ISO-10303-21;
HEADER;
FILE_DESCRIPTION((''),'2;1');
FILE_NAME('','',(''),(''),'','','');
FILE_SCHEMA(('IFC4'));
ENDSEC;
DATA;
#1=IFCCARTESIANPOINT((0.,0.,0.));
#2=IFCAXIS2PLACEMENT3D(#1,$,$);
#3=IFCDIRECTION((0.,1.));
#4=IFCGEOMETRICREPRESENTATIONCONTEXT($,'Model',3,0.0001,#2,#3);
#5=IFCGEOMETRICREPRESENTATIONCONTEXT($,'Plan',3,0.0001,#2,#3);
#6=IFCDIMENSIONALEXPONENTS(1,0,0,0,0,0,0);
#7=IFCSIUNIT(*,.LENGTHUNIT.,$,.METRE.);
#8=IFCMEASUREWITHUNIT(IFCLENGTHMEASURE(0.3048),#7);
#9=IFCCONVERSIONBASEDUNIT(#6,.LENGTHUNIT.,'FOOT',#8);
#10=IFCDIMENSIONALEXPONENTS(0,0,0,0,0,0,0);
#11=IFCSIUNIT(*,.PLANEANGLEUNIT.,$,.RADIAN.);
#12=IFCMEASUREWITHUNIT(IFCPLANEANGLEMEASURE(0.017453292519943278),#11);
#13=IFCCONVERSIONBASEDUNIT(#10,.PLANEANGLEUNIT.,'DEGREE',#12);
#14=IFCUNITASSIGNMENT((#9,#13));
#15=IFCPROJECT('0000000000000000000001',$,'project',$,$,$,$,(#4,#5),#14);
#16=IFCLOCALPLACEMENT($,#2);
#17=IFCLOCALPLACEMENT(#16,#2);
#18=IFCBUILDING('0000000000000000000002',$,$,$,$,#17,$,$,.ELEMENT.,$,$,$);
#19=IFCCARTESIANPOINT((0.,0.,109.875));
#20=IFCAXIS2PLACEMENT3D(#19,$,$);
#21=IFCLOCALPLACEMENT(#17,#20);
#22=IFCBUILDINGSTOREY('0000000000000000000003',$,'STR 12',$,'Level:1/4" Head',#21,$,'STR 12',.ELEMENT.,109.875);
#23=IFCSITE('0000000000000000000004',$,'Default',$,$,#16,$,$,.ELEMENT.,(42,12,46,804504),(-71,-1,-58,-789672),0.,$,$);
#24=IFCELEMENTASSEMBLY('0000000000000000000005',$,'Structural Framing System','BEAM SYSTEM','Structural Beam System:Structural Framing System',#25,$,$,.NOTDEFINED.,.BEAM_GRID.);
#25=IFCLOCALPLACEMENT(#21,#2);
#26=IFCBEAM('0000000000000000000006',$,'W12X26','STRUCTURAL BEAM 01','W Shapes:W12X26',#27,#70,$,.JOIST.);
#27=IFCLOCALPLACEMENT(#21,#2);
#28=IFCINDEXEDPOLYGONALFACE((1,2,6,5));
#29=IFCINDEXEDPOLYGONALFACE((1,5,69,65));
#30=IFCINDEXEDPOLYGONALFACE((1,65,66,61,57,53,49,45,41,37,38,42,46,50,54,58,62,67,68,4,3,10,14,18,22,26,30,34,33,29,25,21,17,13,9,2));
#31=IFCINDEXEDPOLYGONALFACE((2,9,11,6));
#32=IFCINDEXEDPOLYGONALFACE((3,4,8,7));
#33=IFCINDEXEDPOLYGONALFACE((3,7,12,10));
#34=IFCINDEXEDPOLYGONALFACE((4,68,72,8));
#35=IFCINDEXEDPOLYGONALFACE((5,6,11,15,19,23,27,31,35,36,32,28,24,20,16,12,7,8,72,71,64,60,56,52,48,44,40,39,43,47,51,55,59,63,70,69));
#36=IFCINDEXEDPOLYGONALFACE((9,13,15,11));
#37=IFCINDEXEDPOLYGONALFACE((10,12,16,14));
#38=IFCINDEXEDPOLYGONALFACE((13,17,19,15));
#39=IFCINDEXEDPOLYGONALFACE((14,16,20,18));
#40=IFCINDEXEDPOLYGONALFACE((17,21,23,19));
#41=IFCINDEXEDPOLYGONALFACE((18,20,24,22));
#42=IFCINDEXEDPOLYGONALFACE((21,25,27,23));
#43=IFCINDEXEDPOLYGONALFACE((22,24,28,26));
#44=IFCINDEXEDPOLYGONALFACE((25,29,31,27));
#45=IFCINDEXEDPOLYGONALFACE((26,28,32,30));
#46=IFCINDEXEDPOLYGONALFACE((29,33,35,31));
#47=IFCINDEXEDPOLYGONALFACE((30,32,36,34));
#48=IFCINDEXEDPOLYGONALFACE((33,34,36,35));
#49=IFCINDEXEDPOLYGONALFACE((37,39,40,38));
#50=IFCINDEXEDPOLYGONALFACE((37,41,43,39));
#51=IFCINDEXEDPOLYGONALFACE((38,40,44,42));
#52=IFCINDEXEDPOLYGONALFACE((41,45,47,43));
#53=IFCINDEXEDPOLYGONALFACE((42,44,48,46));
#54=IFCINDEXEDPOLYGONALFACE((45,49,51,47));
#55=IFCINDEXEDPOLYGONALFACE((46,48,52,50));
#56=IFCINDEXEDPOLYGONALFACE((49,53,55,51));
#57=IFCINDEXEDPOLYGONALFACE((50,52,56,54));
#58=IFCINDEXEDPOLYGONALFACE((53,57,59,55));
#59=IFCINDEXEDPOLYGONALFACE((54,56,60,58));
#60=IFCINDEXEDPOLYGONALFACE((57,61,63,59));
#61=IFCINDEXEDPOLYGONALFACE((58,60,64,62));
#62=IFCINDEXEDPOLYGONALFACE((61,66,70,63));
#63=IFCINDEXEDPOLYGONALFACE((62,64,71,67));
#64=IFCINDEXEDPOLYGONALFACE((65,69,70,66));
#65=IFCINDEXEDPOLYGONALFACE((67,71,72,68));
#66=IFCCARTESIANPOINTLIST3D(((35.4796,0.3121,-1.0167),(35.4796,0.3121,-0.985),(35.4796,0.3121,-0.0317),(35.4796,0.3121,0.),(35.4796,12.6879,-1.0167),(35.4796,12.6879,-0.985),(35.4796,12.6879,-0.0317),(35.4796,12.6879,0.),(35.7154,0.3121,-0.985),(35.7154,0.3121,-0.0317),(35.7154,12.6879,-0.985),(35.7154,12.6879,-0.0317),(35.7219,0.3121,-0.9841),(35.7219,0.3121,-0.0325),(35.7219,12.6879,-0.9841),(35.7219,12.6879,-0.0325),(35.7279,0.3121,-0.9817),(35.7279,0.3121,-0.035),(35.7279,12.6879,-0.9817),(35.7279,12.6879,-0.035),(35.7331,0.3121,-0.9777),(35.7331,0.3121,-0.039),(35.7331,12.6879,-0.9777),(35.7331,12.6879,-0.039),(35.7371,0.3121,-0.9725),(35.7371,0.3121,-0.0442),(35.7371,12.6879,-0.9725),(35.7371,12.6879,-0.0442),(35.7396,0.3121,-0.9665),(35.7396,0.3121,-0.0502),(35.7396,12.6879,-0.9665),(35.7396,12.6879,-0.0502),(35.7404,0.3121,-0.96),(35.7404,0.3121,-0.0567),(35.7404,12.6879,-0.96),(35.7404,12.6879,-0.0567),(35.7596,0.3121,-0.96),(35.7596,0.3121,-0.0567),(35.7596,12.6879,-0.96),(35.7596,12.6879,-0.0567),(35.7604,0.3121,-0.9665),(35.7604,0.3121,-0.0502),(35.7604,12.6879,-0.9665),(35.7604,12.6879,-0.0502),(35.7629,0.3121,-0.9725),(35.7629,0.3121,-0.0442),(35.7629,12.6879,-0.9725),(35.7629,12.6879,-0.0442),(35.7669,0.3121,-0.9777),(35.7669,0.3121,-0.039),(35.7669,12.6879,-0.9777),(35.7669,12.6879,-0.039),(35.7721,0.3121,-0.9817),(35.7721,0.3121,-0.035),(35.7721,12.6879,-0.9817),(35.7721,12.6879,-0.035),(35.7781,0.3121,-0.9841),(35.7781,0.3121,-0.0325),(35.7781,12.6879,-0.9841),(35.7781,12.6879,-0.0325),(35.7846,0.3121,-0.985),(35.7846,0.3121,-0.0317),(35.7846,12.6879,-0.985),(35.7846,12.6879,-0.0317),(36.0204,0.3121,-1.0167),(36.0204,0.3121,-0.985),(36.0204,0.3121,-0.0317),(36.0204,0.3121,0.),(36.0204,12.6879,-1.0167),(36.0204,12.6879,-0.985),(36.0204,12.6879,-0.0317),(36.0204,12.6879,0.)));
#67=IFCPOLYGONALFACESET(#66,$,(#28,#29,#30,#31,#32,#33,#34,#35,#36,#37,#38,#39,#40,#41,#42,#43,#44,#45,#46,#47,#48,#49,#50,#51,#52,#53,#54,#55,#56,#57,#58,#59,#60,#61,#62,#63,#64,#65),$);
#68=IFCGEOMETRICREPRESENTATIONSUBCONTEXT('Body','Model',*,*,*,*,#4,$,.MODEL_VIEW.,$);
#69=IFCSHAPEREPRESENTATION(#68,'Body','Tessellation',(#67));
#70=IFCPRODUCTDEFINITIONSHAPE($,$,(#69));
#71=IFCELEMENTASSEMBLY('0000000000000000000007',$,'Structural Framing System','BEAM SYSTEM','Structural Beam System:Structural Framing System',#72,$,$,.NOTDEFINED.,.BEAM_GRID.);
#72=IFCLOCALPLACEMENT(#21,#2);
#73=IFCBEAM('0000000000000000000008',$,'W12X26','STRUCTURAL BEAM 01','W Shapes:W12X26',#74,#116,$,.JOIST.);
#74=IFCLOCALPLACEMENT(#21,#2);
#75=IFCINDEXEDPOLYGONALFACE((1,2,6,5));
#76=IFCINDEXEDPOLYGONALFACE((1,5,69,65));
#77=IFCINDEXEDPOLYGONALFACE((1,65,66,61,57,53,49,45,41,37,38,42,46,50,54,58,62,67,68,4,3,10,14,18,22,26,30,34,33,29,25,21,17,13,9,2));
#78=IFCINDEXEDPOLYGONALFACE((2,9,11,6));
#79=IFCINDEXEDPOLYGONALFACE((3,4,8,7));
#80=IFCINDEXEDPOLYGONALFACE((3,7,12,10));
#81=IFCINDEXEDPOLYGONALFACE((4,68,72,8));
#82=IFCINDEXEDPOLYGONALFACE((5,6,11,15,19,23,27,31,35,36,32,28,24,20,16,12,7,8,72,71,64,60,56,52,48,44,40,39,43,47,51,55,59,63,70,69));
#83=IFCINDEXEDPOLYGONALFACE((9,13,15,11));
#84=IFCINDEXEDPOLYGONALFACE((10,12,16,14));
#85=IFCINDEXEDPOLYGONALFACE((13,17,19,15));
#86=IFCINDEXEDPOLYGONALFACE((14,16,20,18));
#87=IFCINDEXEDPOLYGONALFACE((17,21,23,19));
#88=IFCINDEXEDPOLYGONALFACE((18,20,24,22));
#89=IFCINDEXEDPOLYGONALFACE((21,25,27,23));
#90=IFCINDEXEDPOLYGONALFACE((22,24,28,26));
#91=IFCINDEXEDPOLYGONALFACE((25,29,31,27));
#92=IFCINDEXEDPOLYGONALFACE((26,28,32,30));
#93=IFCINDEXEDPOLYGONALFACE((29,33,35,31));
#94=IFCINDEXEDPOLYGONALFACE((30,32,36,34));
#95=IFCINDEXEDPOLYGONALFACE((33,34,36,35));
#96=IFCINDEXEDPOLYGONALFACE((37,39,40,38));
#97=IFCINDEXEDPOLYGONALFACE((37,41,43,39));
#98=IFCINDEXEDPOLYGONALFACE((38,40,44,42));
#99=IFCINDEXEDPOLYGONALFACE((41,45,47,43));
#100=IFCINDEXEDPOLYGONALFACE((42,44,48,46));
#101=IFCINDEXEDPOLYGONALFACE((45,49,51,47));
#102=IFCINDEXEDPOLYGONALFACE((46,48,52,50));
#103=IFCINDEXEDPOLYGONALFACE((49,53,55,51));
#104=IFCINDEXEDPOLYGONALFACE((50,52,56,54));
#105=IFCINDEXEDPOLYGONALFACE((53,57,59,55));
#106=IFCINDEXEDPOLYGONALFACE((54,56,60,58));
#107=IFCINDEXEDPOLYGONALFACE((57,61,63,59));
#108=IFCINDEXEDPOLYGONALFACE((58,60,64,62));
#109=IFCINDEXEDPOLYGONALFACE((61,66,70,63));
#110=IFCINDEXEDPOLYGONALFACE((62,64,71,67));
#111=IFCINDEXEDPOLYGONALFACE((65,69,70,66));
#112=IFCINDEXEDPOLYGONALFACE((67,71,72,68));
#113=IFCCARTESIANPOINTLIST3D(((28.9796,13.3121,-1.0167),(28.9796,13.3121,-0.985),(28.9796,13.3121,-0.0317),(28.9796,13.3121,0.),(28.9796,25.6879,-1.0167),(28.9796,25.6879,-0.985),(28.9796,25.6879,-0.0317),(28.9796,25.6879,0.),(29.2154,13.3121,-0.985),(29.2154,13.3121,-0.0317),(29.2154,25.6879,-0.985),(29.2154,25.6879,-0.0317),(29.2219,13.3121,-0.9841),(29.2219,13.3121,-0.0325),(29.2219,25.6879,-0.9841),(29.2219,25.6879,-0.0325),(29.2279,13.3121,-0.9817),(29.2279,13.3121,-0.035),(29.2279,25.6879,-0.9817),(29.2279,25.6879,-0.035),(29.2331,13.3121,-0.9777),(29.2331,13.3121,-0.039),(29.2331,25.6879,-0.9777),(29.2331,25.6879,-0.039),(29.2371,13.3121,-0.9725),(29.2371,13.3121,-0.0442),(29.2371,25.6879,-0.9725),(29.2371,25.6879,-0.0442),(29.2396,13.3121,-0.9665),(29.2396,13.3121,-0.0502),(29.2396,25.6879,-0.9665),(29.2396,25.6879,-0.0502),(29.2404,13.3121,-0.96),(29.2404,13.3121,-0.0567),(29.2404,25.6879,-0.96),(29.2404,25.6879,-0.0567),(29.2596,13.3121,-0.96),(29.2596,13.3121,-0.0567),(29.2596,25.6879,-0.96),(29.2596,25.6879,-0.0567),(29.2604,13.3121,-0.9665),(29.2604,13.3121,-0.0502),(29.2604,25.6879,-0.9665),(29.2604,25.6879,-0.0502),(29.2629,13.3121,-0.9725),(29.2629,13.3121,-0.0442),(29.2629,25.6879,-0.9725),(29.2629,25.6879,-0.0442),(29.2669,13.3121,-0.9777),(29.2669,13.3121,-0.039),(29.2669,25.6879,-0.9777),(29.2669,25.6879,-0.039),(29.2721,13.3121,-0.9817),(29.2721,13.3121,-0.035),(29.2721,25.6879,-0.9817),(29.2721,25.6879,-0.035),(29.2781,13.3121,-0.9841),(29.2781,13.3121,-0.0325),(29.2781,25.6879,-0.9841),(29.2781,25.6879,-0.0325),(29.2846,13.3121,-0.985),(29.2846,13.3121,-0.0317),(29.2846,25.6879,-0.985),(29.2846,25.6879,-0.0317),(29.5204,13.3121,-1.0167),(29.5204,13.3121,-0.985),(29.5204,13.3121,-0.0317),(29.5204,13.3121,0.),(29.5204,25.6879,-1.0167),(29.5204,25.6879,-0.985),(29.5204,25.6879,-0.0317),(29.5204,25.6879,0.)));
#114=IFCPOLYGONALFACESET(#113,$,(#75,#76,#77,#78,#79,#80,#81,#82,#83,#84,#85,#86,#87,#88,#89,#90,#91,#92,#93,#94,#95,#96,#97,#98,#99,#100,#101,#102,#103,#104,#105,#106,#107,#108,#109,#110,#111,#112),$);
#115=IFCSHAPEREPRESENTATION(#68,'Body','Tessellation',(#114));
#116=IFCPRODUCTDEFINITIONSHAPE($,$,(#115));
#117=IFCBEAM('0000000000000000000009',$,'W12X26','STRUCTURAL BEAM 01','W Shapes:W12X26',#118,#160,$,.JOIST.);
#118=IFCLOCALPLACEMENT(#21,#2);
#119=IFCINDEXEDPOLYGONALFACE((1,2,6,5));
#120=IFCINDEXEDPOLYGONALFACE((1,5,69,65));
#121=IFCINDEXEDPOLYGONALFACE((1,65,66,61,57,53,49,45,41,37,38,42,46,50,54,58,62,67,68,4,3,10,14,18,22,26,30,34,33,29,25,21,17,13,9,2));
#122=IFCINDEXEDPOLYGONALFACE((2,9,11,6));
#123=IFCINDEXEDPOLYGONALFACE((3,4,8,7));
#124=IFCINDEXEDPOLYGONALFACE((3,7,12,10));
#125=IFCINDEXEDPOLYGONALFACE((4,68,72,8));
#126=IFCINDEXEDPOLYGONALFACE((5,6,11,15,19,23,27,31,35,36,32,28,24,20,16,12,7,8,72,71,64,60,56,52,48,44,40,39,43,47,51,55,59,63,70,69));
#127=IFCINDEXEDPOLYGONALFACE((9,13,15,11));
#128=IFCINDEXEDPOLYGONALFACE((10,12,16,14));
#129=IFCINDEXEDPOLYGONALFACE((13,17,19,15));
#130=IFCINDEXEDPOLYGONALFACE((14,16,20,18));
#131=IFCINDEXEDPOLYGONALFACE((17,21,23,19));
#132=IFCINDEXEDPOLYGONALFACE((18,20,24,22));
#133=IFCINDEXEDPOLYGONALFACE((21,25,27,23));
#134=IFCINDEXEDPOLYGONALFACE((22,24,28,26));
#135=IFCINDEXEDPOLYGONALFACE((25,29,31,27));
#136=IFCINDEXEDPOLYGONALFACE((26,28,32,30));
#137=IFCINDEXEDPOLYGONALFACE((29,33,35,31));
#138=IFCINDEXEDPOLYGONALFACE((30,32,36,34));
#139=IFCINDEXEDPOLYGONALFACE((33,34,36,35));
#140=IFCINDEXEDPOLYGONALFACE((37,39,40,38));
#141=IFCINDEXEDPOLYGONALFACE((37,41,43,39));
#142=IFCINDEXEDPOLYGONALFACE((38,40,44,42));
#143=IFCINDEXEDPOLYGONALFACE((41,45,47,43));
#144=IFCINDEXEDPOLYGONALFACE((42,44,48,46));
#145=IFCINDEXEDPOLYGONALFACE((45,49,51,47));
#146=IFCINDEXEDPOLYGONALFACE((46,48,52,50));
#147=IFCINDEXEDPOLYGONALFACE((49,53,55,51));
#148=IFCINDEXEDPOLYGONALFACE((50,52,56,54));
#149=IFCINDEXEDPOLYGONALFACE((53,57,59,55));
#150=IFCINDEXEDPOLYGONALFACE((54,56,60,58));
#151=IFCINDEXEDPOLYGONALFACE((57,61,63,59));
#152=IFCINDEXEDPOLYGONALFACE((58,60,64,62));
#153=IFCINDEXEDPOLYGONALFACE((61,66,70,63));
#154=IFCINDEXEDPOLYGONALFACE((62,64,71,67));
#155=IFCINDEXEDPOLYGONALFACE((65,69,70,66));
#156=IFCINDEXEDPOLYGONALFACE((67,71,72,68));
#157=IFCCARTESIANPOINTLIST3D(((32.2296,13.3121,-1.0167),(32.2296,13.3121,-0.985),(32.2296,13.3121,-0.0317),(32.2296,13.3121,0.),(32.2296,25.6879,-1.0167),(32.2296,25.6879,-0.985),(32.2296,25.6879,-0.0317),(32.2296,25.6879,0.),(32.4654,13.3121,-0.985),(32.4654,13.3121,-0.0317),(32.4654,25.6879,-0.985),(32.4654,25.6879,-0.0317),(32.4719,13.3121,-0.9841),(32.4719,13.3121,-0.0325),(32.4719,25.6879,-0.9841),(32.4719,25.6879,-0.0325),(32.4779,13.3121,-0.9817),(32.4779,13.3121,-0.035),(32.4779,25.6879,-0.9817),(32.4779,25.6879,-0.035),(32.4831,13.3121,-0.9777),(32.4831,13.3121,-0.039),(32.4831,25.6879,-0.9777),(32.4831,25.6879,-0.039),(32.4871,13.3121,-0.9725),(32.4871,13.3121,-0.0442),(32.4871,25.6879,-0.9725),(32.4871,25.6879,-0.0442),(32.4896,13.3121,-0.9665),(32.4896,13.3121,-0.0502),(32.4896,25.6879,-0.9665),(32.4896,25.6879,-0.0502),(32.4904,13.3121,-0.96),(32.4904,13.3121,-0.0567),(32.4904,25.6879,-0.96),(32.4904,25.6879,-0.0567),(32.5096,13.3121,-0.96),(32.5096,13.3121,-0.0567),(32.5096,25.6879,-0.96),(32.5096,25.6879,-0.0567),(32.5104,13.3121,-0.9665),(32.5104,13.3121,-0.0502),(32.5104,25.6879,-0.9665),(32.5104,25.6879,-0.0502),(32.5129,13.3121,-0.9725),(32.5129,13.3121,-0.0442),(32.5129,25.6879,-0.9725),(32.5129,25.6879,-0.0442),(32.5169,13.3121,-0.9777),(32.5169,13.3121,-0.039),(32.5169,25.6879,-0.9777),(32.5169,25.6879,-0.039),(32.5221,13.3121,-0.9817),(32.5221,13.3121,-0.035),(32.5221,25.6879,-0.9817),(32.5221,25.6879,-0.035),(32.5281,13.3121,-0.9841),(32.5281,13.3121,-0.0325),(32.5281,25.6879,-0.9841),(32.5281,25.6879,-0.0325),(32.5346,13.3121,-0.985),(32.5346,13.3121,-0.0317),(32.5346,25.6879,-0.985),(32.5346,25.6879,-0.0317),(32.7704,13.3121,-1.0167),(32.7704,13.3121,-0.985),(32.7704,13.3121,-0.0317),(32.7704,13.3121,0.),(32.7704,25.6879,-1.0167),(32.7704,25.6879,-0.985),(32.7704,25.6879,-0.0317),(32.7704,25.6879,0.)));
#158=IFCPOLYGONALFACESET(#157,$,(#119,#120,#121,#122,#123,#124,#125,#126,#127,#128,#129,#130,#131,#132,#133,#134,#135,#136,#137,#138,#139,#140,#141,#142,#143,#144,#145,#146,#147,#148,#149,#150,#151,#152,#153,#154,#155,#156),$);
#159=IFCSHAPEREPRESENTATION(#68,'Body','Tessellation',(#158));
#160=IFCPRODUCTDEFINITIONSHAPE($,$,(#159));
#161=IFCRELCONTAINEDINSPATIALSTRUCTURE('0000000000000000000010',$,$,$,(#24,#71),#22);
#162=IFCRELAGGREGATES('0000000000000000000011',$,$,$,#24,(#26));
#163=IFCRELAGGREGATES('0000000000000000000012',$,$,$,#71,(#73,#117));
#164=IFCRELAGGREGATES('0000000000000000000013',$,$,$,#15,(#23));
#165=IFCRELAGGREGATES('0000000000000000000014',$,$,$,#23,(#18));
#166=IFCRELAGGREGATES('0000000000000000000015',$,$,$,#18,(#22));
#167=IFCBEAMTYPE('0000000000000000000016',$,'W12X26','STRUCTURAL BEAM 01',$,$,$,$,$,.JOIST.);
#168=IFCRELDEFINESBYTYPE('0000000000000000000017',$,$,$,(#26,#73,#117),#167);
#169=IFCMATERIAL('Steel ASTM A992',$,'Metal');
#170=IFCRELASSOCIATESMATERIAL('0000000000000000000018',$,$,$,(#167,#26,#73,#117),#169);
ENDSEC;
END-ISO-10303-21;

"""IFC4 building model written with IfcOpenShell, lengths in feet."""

from ifc_helpers import new_model, entity, si_unit, converted_unit, direction, frame, origin, place, context, subcontext, project, spatial, line, arc, indexed_curve, outline, extrude, source, transform, mapped, material, type_object, type_shapes, element, aggregate, save


model = new_model("IFC4")

# Units and contexts
model_context = context("Model", 3, precision=0.0001, world=origin(), true_north=direction((0.0, 1.0)))
plan_context = context("Plan", 3, precision=0.0001, world=origin(), true_north=direction((0.0, 1.0)))
body_context = subcontext(model_context, "Body", "Model", "MODEL_VIEW")
ifc_project = project(units=[converted_unit("LENGTHUNIT", "FOOT", entity("IfcLengthMeasure", 0.3048), si_unit("LENGTHUNIT", "METRE"), dimensions=[1, 0, 0, 0, 0, 0, 0]), converted_unit("PLANEANGLEUNIT", "DEGREE", entity("IfcPlaneAngleMeasure", 0.017453292519943278), si_unit("PLANEANGLEUNIT", "RADIAN"), dimensions=[0, 0, 0, 0, 0, 0, 0])], contexts=[model_context, plan_context])

# Site, building, storey
site_placement = place(None, origin())
site = spatial("IfcSite", under=ifc_project, at=site_placement, Name="Default", CompositionType="ELEMENT", RefLatitude=(42, 12, 46, 804504), RefLongitude=(-71, -1, -58, -789672), RefElevation=0.0)
building_placement = place(site_placement, origin())
building = spatial("IfcBuilding", under=site, at=building_placement, CompositionType="ELEMENT")
storey_placement = place(building_placement, frame((0.0, 0.0, 109.875)))
storey = spatial("IfcBuildingStorey", under=building, at=storey_placement, Name="STR 12", ObjectType="Level:1/4\" Head", LongName="STR 12", CompositionType="ELEMENT", Elevation=109.875)

# Element assemblies, beams
ifc_material = material(Name="Steel ASTM A992", Category="Metal")
beam_type = type_object("IfcBeamType", Name="W12X26", Description="STRUCTURAL BEAM 01", PredefinedType="JOIST", material=ifc_material)
shared_shape = source(origin(), body_context, "Body", "SweptSolid", [
    extrude(outline(indexed_curve([(-0.2704, -0.4767), (-0.2704, -0.5083), (0.2704, -0.5083), (0.2704, -0.4767), (0.0346, -0.4767), (0.0169, -0.4693), (0.0096, -0.4517), (0.0096, 0.4517), (0.0169, 0.4693), (0.0346, 0.4767), (0.2704, 0.4767), (0.2704, 0.5083), (-0.2704, 0.5083), (-0.2704, 0.4767), (-0.0346, 0.4767), (-0.0169, 0.4693), (-0.0096, 0.4517), (-0.0096, -0.4517), (-0.0169, -0.4693), (-0.0346, -0.4767)], segments=[line(1, 2, 3, 4, 5), arc(5, 6, 7), line(7, 8), arc(8, 9, 10), line(10, 11, 12, 13, 14, 15), arc(15, 16, 17), line(17, 18), arc(18, 19, 20), line(20, 1)], self_intersect=False)), frame((-6.1879, 0.0, 0.0), z_axis=(-1.0, 0.0, 0.0), x_axis=(0.0, -1.0, 0.0)), (0.0, 0.0, -1.0), 12.3758),
])
type_shapes(beam_type, [shared_shape])
assembly_1_placement = place(storey_placement, origin())
assembly_1 = element("IfcElementAssembly", 1, at=assembly_1_placement, inside=storey, Name="Structural Framing System", Description="BEAM SYSTEM", ObjectType="Structural Beam System:Structural Framing System", AssemblyPlace="NOTDEFINED", PredefinedType="BEAM_GRID")
beam_1_placement = place(assembly_1_placement, frame((35.75, 6.5, -0.5083), z_axis=(0.0, 0.0, 1.0), x_axis=(0.0, 1.0, 0.0)))
beam_1 = element("IfcBeam", 2, at=beam_1_placement, type_object=beam_type, material=ifc_material, Name="W12X26", Description="STRUCTURAL BEAM 01", ObjectType="W Shapes:W12X26", PredefinedType="JOIST", context=body_context, shape_type="MappedRepresentation", body=[
    mapped(shared_shape, transform((0.0, 0.0, 0.0), scale=1.0)),
])
aggregate(assembly_1, [beam_1])
assembly_2_placement = place(storey_placement, origin())
assembly_2 = element("IfcElementAssembly", 3, at=assembly_2_placement, inside=storey, Name="Structural Framing System", Description="BEAM SYSTEM", ObjectType="Structural Beam System:Structural Framing System", AssemblyPlace="NOTDEFINED", PredefinedType="BEAM_GRID")
beam_2_placement = place(assembly_2_placement, frame((29.25, 19.5, -0.5083), z_axis=(0.0, 0.0, 1.0), x_axis=(0.0, 1.0, 0.0)))
beam_2 = element("IfcBeam", 4, at=beam_2_placement, type_object=beam_type, material=ifc_material, Name="W12X26", Description="STRUCTURAL BEAM 01", ObjectType="W Shapes:W12X26", PredefinedType="JOIST", context=body_context, shape_type="MappedRepresentation", body=[
    mapped(shared_shape, transform((0.0, 0.0, 0.0), scale=1.0)),
])
beam_3_placement = place(assembly_2_placement, frame((32.5, 19.5, -0.5083), z_axis=(0.0, 0.0, 1.0), x_axis=(0.0, 1.0, 0.0)))
beam_3 = element("IfcBeam", 5, at=beam_3_placement, type_object=beam_type, material=ifc_material, Name="W12X26", Description="STRUCTURAL BEAM 01", ObjectType="W Shapes:W12X26", PredefinedType="JOIST", context=body_context, shape_type="MappedRepresentation", body=[
    mapped(shared_shape, transform((0.0, 0.0, 0.0), scale=1.0)),
])
aggregate(assembly_2, [beam_2, beam_3])

save(model, "model.ifc")
